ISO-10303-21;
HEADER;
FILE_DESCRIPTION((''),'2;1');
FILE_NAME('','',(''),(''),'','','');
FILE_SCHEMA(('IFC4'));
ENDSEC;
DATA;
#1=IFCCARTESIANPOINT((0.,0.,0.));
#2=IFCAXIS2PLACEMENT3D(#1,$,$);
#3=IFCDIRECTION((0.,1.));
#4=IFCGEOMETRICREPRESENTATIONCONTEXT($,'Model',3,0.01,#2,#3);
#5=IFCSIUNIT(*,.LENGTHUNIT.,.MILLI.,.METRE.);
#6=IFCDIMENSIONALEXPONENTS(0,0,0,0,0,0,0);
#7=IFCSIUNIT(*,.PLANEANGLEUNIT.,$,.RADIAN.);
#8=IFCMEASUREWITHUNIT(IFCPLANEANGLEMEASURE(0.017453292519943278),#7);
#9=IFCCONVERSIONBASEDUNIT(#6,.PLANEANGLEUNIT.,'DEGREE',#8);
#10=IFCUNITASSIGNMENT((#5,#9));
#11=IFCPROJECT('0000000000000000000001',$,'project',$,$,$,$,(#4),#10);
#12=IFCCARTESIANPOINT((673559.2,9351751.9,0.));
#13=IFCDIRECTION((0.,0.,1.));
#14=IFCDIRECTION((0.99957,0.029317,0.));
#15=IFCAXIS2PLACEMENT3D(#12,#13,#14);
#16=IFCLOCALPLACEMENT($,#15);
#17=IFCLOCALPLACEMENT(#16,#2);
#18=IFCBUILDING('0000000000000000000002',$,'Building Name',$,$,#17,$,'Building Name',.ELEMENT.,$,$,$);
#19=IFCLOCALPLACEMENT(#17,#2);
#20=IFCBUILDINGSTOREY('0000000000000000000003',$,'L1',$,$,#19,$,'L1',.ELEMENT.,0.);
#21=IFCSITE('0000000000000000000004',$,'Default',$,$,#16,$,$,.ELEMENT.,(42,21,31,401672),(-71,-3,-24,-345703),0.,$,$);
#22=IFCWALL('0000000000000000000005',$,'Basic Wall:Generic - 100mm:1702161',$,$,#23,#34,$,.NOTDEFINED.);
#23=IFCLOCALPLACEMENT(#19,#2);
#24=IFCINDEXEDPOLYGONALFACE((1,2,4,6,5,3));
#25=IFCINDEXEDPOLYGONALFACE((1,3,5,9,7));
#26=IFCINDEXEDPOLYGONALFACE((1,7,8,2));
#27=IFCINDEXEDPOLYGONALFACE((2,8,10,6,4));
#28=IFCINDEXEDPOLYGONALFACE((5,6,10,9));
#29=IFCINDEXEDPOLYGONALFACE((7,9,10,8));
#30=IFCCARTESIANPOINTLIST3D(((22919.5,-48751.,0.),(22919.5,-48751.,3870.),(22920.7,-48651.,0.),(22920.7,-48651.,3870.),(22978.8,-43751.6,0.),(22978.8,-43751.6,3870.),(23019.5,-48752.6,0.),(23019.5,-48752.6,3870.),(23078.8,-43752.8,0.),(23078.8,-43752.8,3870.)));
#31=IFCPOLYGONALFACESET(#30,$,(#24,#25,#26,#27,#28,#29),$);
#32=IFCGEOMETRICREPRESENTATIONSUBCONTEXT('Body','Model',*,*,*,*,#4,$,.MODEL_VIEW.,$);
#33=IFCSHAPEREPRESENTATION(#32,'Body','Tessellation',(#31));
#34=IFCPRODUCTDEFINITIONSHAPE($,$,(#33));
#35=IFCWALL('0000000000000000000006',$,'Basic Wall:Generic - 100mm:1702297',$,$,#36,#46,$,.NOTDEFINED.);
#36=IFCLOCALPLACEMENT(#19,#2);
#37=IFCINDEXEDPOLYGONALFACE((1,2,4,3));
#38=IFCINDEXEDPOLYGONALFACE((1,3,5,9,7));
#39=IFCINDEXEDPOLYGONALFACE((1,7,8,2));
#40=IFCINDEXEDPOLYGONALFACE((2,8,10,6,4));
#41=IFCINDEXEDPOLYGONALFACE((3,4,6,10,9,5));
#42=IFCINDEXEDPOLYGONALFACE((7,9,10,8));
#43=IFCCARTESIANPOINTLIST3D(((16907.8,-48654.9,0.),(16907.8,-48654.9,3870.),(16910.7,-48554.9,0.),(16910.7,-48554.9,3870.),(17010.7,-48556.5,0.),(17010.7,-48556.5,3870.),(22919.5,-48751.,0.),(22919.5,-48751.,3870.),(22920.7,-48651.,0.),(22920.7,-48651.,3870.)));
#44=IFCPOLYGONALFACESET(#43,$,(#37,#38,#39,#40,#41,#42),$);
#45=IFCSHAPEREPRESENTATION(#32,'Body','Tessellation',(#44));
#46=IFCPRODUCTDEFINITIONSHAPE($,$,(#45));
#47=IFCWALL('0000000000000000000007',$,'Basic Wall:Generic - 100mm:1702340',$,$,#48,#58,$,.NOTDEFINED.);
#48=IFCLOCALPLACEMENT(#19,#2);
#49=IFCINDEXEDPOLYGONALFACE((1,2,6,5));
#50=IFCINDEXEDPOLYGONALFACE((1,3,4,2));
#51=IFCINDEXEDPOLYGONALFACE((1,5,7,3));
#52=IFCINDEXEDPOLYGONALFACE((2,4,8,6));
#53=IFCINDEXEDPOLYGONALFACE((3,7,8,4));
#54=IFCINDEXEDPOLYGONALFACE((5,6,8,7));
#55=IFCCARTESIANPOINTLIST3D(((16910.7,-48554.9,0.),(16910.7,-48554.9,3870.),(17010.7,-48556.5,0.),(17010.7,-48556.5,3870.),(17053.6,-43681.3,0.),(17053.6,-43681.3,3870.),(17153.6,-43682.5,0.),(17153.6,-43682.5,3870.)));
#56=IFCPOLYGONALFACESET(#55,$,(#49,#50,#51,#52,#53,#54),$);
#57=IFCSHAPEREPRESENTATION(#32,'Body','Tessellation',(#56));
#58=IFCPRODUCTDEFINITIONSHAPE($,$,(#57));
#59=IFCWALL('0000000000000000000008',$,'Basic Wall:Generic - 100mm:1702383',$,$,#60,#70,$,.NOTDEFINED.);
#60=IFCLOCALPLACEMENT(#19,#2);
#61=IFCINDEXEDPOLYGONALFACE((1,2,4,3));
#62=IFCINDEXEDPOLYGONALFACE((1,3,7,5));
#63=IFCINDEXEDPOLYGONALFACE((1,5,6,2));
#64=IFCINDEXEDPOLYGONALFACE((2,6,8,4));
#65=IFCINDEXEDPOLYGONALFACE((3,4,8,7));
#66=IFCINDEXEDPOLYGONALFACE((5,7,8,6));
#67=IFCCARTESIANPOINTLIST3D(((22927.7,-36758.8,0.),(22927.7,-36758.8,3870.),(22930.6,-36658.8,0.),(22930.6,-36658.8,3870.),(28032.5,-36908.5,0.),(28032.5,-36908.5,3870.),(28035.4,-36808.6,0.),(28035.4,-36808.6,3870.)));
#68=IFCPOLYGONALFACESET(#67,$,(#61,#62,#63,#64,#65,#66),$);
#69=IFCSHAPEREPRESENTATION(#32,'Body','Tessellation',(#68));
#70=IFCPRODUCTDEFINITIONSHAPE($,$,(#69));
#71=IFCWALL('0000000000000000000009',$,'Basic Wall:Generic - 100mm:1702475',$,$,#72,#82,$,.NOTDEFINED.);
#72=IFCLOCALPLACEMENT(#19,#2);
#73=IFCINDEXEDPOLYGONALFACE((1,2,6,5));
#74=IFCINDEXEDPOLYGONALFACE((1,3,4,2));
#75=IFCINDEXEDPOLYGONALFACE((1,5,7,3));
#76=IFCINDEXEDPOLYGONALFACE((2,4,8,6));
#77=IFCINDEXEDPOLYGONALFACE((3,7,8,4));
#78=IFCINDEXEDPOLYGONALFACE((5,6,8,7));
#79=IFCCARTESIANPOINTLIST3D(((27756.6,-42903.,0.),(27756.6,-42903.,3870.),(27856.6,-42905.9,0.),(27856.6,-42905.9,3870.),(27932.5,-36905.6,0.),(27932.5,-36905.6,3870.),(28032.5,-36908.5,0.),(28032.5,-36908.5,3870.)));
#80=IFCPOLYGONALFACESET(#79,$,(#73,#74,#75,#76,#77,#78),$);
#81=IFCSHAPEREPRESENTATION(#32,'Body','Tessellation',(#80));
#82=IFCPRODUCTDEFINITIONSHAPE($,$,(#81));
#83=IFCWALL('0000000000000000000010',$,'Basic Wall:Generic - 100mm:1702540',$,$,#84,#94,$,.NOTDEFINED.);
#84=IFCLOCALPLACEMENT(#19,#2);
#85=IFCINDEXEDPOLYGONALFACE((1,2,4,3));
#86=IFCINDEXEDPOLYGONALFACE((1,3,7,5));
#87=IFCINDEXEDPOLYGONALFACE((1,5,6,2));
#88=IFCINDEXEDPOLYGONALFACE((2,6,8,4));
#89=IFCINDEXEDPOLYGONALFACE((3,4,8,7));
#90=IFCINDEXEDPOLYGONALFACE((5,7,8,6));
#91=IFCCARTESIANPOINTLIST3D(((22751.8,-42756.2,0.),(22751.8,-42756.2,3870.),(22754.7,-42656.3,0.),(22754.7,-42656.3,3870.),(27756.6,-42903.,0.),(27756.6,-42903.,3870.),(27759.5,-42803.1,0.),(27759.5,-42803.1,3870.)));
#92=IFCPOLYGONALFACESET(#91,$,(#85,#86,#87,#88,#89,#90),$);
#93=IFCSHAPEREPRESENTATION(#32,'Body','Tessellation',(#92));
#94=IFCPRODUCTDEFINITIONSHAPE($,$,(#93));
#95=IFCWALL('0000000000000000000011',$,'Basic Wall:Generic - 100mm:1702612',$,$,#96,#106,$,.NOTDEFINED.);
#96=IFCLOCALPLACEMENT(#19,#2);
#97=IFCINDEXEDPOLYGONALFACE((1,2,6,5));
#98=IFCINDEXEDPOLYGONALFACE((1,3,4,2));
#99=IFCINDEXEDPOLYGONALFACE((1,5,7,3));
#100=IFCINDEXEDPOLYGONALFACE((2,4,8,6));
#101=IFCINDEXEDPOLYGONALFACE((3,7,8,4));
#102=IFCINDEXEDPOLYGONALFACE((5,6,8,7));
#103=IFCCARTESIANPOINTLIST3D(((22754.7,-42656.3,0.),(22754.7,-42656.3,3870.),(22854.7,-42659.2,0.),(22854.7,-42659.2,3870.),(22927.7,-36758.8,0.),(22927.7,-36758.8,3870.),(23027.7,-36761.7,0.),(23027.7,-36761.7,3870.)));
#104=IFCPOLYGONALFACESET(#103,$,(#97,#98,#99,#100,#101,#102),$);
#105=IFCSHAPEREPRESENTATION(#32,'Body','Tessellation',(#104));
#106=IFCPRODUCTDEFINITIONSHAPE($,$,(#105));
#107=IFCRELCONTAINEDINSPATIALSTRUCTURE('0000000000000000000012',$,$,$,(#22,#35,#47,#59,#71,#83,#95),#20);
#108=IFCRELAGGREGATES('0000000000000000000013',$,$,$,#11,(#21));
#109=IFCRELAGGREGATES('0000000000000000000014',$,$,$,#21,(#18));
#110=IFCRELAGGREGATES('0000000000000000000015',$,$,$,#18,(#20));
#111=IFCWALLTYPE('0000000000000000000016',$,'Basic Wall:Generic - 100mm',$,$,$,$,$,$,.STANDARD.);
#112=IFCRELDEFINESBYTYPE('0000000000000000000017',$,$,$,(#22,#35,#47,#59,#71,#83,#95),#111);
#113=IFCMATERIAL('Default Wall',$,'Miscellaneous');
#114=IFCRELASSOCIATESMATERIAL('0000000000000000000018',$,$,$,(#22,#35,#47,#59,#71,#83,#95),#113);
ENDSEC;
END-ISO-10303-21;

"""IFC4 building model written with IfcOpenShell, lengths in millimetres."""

from ifc_helpers import new_model, entity, si_unit, converted_unit, direction, frame, origin, place, context, subcontext, project, spatial, indexed_curve, outline, extrude, material, type_object, element, save


model = new_model("IFC4")

# Units and contexts
model_context = context("Model", 3, precision=0.01, world=origin(), true_north=direction((0.0, 1.0)))
body_context = subcontext(model_context, "Body", "Model", "MODEL_VIEW")
ifc_project = project(units=[si_unit("LENGTHUNIT", "METRE", prefix="MILLI"), converted_unit("PLANEANGLEUNIT", "DEGREE", entity("IfcPlaneAngleMeasure", 0.017453292519943278), si_unit("PLANEANGLEUNIT", "RADIAN"), dimensions=[0, 0, 0, 0, 0, 0, 0])], contexts=[model_context])

# Site, building, storey
site_placement = place(None, frame((673559.2, 9351751.9, 0.0), z_axis=(0.0, 0.0, 1.0), x_axis=(0.99957, 0.029317, 0.0)))
site = spatial("IfcSite", under=ifc_project, at=site_placement, Name="Default", CompositionType="ELEMENT", RefLatitude=(42, 21, 31, 401672), RefLongitude=(-71, -3, -24, -345703), RefElevation=0.0)
building_placement = place(site_placement, origin())
building = spatial("IfcBuilding", under=site, at=building_placement, Name="Building Name", LongName="Building Name", CompositionType="ELEMENT")
storey_placement = place(building_placement, origin())
storey = spatial("IfcBuildingStorey", under=building, at=storey_placement, Name="L1", LongName="L1", CompositionType="ELEMENT", Elevation=0.0)

# Walls
ifc_material = material(Name="Default Wall", Category="Miscellaneous")
wall_type_1 = type_object("IfcWallType", Name="Basic Wall:Generic - 100mm", PredefinedType="STANDARD")
wall_1_placement = place(storey_placement, frame((23028.8, -43752.2, 0.0), z_axis=(0.0, 0.0, 1.0), x_axis=(-0.011868, -0.99993, 0.0)))
element("IfcWall", 1, at=wall_1_placement, inside=storey, type_object=wall_type_1, material=ifc_material, Name="Basic Wall:Generic - 100mm:1702161", PredefinedType="NOTDEFINED", context=body_context, shape_type="SweptSolid", body=[
    extrude(outline(indexed_curve([(4999.8, -50.0), (5000.2, 50.0), (0.0, 50.0), (0.0, -50.0), (4899.8, -50.0), (4999.8, -50.0)], self_intersect=False)), origin(), (0.0, 0.0, 1.0), 3870.0),
])
wall_2_placement = place(storey_placement, frame((22920.3, -48701.0, 0.0), z_axis=(0.0, 0.0, 1.0), x_axis=(-0.999872, 0.015998, 0.0)))
element("IfcWall", 2, at=wall_2_placement, inside=storey, type_object=wall_type_1, material=ifc_material, Name="Basic Wall:Generic - 100mm:1702297", PredefinedType="NOTDEFINED", context=body_context, shape_type="SweptSolid", body=[
    extrude(outline(indexed_curve([(6011.2, -50.0), (6012.5, 50.0), (0.0, 50.0), (0.4, -50.0), (5911.2, -50.0), (6011.2, -50.0)], self_intersect=False)), origin(), (0.0, 0.0, 1.0), 3870.0),
])
wall_3_placement = place(storey_placement, frame((16960.7, -48556.4, 0.0), z_axis=(0.0, 0.0, 1.0), x_axis=(0.029317, 0.99957, 0.0)))
element("IfcWall", 3, at=wall_3_placement, inside=storey, type_object=wall_type_1, material=ifc_material, Name="Basic Wall:Generic - 100mm:1702340", PredefinedType="NOTDEFINED", context=body_context, shape_type="SweptSolid", body=[
    extrude(outline(indexed_curve([(4877.5, -50.0), (4875.7, 50.0), (0.0, 50.0), (1.3, -50.0), (4877.5, -50.0)], self_intersect=False)), origin(), (0.0, 0.0, 1.0), 3870.0),
])
wall_4_placement = place(storey_placement, frame((22929.2, -36708.8, 0.0), z_axis=(0.0, 0.0, 1.0), x_axis=(0.99957, -0.029317, 0.0)))
element("IfcWall", 4, at=wall_4_placement, inside=storey, type_object=wall_type_1, material=ifc_material, Name="Basic Wall:Generic - 100mm:1702383", PredefinedType="NOTDEFINED", context=body_context, shape_type="SweptSolid", body=[
    extrude(outline(indexed_curve([(5106.9, 50.0), (0.0, 50.0), (0.0, -50.0), (5106.9, -50.0), (5106.9, 50.0)], self_intersect=False)), origin(), (0.0, 0.0, 1.0), 3870.0),
])
wall_5_placement = place(storey_placement, frame((27982.5, -36907.1, 0.0), z_axis=(0.0, 0.0, 1.0), x_axis=(-0.029317, -0.99957, 0.0)))
element("IfcWall", 5, at=wall_5_placement, inside=storey, type_object=wall_type_1, material=ifc_material, Name="Basic Wall:Generic - 100mm:1702475", PredefinedType="NOTDEFINED", context=body_context, shape_type="SweptSolid", body=[
    extrude(outline(indexed_curve([(6000.0, 50.0), (0.0, 50.0), (0.0, -50.0), (6000.0, -50.0), (6000.0, 50.0)], self_intersect=False)), origin(), (0.0, 0.0, 1.0), 3870.0),
])
wall_6_placement = place(storey_placement, frame((27758.1, -42853.0, 0.0), z_axis=(0.0, 0.0, 1.0), x_axis=(-0.99957, 0.029317, 0.0)))
element("IfcWall", 6, at=wall_6_placement, inside=storey, type_object=wall_type_1, material=ifc_material, Name="Basic Wall:Generic - 100mm:1702540", PredefinedType="NOTDEFINED", context=body_context, shape_type="SweptSolid", body=[
    extrude(outline(indexed_curve([(5006.9, 50.0), (0.0, 50.0), (0.0, -50.0), (5006.9, -50.0), (5006.9, 50.0)], self_intersect=False)), origin(), (0.0, 0.0, 1.0), 3870.0),
])
wall_7_placement = place(storey_placement, frame((22804.7, -42657.7, 0.0), z_axis=(0.0, 0.0, 1.0), x_axis=(0.029317, 0.99957, 0.0)))
element("IfcWall", 7, at=wall_7_placement, inside=storey, type_object=wall_type_1, material=ifc_material, Name="Basic Wall:Generic - 100mm:1702612", PredefinedType="NOTDEFINED", context=body_context, shape_type="SweptSolid", body=[
    extrude(outline(indexed_curve([(5900.0, 50.0), (0.0, 50.0), (0.0, -50.0), (5900.0, -50.0), (5900.0, 50.0)], self_intersect=False)), origin(), (0.0, 0.0, 1.0), 3870.0),
])

save(model, "model.ifc")
